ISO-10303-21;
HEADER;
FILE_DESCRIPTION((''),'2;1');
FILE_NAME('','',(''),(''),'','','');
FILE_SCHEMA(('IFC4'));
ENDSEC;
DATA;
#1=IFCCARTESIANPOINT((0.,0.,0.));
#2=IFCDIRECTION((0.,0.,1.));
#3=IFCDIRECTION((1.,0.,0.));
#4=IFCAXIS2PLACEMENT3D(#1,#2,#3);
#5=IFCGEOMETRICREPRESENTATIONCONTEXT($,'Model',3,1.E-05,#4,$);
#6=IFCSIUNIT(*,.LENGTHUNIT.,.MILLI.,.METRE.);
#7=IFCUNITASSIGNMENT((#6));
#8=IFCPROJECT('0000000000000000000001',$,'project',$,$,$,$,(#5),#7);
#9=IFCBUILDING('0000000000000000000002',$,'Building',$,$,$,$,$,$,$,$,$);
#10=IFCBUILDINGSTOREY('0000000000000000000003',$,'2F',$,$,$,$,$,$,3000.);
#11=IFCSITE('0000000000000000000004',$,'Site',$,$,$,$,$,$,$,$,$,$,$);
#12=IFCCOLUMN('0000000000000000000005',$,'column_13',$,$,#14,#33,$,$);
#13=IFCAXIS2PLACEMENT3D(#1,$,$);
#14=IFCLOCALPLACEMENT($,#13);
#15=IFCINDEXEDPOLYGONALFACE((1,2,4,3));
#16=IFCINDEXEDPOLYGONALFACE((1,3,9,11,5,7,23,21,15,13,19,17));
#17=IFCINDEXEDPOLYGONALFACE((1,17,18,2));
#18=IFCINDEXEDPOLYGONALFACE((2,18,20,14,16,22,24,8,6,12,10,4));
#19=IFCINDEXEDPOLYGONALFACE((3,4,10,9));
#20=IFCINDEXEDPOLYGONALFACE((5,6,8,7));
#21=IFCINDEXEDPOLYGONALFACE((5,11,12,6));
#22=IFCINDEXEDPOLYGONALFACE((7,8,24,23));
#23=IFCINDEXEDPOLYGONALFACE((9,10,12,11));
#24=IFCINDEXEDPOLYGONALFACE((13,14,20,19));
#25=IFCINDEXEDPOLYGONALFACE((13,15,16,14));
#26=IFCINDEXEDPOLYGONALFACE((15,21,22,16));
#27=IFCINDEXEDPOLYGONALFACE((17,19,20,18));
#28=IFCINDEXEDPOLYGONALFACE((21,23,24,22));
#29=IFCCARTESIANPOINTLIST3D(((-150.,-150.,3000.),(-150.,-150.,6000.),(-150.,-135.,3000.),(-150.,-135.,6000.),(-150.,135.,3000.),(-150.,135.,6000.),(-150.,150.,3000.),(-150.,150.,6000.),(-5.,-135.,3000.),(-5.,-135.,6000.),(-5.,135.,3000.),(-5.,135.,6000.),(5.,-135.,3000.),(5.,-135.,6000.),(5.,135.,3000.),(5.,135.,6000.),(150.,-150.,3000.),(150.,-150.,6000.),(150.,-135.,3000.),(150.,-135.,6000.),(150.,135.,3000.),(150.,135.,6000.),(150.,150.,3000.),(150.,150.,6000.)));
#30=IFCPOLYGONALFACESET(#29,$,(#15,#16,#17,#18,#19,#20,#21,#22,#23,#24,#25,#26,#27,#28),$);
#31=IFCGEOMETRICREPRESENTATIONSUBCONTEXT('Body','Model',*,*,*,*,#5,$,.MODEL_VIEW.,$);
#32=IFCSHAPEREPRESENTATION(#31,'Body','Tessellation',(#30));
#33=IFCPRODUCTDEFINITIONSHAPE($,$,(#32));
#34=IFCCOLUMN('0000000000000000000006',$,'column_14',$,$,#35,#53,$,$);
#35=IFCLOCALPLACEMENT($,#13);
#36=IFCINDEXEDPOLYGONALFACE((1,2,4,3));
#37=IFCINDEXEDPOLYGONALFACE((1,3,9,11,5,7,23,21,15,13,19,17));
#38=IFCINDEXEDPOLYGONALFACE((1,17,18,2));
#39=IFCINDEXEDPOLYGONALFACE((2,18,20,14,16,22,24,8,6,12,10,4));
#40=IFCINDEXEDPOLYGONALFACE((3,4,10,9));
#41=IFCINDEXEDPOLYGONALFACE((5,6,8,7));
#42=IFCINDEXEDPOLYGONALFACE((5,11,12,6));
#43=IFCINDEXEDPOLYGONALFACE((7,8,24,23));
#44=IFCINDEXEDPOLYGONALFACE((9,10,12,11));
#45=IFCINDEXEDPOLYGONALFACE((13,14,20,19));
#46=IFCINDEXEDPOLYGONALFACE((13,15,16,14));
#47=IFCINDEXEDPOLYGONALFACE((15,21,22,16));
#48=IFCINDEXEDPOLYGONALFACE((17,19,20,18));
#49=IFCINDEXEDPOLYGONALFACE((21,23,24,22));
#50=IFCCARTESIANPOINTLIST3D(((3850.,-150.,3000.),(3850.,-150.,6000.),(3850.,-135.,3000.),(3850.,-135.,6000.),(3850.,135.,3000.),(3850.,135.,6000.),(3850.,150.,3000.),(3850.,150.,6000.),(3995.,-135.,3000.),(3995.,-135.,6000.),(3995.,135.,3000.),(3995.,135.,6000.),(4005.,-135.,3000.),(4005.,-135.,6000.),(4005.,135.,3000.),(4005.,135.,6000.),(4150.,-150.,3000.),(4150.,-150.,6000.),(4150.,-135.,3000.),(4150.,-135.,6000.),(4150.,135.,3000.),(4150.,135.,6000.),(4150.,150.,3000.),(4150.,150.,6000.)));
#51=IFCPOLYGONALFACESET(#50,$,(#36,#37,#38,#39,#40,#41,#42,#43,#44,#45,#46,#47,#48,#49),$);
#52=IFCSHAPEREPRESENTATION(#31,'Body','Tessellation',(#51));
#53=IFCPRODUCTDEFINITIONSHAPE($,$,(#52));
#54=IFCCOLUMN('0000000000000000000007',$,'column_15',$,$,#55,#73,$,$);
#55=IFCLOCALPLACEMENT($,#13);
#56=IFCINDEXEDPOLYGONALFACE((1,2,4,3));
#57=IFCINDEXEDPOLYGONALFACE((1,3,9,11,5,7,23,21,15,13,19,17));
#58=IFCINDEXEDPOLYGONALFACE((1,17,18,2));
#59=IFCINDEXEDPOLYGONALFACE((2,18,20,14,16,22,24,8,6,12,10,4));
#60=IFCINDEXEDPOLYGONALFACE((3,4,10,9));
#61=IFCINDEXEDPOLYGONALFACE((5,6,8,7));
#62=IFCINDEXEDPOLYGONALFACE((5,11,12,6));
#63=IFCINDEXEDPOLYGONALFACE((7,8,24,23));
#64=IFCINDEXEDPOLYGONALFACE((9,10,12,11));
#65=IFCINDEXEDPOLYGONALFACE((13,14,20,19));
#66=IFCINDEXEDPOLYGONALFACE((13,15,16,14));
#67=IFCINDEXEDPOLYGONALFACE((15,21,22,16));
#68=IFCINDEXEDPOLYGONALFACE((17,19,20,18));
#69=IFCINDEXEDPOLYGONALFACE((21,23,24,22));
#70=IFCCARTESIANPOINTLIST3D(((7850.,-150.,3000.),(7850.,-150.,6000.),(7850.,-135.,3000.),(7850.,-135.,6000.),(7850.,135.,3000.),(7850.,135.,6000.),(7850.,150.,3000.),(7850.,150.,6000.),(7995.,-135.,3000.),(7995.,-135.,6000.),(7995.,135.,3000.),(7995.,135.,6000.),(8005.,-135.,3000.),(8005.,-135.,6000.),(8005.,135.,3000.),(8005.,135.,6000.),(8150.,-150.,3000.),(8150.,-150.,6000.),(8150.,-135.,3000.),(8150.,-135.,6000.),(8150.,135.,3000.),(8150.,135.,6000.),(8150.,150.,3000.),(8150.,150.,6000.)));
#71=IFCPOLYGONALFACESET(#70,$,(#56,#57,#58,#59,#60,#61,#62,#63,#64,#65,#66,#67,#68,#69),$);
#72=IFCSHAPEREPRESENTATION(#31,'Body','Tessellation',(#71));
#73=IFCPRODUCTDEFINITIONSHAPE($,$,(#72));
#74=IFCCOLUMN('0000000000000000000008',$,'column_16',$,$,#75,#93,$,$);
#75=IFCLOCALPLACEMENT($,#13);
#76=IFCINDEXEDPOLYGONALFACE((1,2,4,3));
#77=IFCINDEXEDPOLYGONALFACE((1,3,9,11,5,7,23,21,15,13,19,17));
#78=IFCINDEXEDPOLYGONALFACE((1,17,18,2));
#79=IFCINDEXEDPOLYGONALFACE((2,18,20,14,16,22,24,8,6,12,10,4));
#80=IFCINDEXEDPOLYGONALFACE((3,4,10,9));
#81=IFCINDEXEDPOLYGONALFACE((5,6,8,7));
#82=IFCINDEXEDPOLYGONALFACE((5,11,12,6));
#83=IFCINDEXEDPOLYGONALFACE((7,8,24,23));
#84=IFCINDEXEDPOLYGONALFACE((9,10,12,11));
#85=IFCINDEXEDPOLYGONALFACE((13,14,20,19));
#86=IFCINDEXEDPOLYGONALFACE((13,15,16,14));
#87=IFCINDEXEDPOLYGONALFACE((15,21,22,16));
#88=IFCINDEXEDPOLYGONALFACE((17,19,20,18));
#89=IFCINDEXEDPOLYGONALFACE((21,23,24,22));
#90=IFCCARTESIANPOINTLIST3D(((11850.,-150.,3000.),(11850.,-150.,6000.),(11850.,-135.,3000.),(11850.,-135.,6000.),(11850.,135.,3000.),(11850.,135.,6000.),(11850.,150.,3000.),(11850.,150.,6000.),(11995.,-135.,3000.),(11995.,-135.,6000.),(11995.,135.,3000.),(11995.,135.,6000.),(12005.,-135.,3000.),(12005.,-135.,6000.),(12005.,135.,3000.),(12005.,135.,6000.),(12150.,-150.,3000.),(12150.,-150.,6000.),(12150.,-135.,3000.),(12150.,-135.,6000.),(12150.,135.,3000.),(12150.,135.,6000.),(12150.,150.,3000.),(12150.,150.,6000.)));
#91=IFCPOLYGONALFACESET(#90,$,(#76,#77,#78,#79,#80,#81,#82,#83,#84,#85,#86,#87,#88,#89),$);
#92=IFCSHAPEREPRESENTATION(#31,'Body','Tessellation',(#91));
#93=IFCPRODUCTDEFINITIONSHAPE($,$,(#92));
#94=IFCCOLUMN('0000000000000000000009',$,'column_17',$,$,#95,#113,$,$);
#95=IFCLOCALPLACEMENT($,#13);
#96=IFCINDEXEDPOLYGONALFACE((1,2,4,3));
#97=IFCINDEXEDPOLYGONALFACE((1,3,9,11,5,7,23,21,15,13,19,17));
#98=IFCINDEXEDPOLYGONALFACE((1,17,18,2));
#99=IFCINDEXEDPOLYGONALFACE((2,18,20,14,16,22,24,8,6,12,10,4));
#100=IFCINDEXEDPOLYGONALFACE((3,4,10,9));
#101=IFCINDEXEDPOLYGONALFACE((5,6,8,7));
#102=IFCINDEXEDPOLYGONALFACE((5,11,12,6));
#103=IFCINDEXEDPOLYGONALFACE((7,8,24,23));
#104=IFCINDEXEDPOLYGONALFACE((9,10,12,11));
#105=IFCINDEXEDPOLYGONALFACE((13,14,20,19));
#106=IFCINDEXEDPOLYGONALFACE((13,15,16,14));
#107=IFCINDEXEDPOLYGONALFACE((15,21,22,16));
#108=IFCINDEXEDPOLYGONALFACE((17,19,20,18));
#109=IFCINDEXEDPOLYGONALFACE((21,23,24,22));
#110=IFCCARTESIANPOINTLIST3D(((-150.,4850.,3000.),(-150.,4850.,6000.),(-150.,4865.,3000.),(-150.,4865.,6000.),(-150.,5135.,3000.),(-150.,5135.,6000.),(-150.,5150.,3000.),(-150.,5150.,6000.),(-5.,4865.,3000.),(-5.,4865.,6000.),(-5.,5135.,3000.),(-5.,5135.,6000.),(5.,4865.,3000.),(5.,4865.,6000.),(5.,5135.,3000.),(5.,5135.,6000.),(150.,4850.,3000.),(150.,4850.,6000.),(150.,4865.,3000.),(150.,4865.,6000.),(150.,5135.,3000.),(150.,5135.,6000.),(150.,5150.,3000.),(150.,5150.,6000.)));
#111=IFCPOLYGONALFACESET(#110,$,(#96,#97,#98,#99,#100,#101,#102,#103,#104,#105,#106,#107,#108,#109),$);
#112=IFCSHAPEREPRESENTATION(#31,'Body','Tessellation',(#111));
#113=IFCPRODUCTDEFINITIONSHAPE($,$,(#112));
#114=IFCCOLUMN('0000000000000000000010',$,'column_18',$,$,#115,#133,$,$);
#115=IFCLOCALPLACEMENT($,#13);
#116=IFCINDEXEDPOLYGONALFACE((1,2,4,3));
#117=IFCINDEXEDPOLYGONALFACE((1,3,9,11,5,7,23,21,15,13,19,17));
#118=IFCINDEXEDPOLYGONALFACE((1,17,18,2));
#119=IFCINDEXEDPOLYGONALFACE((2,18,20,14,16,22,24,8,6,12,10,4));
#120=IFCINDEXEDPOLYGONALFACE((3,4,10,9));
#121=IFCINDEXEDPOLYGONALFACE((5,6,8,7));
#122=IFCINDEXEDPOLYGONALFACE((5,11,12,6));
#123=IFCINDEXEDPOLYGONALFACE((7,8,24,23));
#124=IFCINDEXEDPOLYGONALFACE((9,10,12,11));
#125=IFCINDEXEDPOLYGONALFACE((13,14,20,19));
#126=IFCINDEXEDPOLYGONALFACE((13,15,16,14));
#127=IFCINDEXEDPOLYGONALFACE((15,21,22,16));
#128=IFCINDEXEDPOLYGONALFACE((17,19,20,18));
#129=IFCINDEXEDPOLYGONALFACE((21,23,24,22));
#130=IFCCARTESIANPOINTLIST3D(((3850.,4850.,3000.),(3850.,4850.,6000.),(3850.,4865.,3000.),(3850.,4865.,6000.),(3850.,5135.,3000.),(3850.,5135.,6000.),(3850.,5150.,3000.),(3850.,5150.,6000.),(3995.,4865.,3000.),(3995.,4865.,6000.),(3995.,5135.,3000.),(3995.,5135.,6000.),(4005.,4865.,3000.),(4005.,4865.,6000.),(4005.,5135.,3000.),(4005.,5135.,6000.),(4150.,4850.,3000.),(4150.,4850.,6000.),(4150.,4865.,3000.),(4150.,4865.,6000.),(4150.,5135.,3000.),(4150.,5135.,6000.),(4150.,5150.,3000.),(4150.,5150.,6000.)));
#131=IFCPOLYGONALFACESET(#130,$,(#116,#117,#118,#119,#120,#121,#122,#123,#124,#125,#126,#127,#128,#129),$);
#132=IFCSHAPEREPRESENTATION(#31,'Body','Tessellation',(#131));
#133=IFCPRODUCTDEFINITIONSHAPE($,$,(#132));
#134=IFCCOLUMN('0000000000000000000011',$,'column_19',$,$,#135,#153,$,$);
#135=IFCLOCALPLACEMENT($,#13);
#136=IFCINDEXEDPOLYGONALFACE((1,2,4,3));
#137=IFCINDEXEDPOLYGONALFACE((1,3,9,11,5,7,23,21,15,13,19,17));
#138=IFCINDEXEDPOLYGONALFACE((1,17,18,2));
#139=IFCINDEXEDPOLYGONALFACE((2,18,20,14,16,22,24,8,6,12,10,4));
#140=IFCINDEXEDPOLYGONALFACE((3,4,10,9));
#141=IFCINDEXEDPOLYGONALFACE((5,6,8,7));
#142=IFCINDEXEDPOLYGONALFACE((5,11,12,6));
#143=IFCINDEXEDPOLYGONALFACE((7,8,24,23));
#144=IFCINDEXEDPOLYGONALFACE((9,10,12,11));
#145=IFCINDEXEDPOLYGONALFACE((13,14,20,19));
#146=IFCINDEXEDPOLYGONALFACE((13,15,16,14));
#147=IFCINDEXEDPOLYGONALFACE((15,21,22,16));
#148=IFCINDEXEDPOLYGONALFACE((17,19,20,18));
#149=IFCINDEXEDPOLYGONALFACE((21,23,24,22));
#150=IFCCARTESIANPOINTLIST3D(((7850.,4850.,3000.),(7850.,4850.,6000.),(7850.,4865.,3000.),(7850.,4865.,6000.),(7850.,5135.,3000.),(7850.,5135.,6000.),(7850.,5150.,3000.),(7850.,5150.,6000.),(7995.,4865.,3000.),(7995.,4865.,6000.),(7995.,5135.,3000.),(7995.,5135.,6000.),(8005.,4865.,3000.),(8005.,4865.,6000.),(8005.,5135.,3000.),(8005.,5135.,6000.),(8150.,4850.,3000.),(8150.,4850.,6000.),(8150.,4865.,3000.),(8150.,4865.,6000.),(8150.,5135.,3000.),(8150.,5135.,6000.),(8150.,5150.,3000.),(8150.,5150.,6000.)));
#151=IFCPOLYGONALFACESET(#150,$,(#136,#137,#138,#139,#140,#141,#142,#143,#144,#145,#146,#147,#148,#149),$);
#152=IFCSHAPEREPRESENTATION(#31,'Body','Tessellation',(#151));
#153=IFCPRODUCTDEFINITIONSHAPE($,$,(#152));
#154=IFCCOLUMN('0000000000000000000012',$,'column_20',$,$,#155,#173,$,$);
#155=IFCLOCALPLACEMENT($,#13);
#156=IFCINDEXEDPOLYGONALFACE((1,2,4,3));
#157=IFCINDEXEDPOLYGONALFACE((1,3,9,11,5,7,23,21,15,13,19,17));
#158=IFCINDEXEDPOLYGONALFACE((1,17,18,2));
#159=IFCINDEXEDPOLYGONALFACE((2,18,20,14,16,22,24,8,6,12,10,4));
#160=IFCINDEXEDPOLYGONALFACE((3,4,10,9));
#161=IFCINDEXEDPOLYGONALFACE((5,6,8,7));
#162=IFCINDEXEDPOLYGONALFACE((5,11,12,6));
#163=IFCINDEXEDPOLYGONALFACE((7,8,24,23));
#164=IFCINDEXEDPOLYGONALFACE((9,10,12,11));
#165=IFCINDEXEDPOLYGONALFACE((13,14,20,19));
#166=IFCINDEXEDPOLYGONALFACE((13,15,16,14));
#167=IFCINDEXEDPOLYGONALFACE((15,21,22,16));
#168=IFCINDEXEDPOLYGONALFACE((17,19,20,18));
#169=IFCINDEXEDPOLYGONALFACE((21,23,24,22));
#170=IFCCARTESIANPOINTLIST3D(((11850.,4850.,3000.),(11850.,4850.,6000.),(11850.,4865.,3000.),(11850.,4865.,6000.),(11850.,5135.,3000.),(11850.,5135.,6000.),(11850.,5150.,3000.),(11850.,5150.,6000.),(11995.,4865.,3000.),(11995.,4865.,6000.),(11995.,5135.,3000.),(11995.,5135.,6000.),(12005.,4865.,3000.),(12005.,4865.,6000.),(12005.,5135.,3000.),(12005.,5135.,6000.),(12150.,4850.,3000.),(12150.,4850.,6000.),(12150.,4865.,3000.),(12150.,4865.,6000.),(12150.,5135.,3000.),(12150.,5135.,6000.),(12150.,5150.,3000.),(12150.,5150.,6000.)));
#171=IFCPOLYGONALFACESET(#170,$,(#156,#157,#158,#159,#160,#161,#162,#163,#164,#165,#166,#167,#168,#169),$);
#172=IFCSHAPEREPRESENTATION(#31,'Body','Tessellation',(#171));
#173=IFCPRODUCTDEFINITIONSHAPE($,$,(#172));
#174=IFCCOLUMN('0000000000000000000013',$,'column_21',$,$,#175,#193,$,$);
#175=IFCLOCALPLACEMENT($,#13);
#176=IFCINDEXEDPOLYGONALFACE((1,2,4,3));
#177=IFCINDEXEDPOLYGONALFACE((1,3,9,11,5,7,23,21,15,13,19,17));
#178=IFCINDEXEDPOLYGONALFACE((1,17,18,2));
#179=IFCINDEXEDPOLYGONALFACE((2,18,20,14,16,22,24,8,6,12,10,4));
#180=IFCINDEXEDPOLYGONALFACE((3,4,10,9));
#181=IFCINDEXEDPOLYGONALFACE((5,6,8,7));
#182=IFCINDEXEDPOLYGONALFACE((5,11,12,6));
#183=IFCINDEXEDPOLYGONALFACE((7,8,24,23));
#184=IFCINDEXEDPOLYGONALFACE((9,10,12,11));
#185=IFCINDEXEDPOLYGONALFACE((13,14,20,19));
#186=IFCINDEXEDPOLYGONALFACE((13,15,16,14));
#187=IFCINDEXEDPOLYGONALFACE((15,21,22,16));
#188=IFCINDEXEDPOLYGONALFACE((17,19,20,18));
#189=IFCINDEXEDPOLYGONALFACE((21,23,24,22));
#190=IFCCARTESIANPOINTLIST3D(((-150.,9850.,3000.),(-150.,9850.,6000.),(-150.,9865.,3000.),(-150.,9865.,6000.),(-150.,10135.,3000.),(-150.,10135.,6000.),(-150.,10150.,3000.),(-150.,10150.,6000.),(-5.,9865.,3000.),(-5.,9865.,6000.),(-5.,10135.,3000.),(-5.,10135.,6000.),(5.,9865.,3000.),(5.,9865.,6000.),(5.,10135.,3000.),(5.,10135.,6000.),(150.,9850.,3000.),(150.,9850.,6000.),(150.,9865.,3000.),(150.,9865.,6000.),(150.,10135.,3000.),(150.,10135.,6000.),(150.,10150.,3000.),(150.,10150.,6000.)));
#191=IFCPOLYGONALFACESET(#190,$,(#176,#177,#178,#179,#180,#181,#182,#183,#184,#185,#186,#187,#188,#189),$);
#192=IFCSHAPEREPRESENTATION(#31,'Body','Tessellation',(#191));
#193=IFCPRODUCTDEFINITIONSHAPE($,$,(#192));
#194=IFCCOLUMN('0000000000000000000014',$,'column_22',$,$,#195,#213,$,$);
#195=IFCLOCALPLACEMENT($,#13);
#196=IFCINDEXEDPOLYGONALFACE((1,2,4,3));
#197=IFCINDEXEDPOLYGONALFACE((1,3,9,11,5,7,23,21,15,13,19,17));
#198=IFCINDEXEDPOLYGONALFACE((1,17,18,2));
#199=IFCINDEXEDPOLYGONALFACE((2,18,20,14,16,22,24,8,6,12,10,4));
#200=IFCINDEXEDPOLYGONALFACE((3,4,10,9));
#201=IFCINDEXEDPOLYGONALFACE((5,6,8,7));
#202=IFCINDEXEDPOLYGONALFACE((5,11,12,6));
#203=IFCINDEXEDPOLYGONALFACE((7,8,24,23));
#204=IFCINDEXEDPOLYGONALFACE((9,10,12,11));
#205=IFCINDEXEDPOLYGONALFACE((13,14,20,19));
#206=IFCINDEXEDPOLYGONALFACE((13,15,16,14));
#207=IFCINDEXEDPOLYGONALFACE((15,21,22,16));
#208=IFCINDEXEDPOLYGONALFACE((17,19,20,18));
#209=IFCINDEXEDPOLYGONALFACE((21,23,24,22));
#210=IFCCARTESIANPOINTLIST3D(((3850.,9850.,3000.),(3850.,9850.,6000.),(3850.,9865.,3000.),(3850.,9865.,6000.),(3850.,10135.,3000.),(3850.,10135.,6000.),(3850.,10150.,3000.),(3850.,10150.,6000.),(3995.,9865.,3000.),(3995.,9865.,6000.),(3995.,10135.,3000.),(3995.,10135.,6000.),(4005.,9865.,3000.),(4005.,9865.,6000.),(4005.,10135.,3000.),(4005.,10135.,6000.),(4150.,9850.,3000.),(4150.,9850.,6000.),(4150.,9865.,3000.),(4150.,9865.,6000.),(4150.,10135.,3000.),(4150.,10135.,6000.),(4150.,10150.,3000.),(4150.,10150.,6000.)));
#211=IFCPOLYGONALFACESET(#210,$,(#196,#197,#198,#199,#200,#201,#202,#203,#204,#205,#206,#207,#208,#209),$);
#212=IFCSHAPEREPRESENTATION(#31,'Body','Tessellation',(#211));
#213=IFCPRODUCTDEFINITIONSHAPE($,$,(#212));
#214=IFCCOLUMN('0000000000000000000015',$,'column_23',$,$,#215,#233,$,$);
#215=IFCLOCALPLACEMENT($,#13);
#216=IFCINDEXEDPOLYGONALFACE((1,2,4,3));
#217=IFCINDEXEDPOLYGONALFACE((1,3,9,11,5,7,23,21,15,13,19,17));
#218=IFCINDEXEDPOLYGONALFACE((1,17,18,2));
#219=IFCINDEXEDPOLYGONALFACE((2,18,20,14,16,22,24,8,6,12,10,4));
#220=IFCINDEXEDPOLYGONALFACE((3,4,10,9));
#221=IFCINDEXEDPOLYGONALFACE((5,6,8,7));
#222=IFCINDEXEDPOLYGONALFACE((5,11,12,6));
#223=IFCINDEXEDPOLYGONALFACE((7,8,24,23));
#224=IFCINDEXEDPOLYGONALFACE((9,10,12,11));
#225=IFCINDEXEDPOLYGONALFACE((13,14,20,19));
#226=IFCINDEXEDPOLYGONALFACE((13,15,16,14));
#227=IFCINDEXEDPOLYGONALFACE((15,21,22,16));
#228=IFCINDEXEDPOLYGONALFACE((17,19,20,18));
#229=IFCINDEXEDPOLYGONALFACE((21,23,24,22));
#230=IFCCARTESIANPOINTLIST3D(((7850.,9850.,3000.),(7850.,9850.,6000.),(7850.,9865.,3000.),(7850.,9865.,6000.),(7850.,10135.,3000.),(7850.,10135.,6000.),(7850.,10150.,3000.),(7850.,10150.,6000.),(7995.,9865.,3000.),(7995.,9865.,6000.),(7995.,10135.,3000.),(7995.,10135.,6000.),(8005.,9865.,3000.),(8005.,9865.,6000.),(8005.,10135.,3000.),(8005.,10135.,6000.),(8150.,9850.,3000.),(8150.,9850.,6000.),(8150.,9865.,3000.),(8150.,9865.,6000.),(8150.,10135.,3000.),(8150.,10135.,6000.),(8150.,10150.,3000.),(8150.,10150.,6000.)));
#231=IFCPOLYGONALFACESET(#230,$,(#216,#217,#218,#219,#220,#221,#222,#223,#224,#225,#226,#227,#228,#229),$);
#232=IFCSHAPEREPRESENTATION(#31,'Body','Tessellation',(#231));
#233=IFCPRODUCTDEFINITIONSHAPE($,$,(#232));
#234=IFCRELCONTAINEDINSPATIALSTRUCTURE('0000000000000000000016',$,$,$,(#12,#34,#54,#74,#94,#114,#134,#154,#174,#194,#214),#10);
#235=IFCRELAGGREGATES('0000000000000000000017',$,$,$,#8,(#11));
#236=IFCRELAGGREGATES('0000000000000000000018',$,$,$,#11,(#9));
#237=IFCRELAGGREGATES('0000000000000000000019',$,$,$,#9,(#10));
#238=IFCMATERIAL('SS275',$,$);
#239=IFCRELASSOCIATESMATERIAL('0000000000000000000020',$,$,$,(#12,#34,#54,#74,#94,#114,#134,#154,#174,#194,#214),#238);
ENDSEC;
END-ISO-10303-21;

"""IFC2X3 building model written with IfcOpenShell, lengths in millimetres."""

from ifc_helpers import new_model, si_unit, frame, origin, origin_with_axes, origin_2d_with_axis, place, context, subcontext, project, spatial, i_section, extrude, material, element, save


model = new_model("IFC2X3")

# Units and contexts
model_context = context("Model", 3, precision=1e-05, world=origin_with_axes())
body_context = subcontext(model_context, "Body", "Model", "MODEL_VIEW")
ifc_project = project(units=[si_unit("LENGTHUNIT", "METRE", prefix="MILLI")], contexts=[model_context])

# Site, building, storey
site = spatial("IfcSite", under=ifc_project, Name="Site")
building = spatial("IfcBuilding", under=site, Name="Building")
storey = spatial("IfcBuildingStorey", under=building, Name="2F", Elevation=3000.0)

# Columns
ifc_material = material(Name="SS275")
for number, where, z_axis, x_axis, name in (
    (1, (0.0, 0.0, 3000.0), (0.0, 0.0, 1.0), (1.0, 0.0, 0.0), "column_13"),
    (2, (4000.0, 0.0, 3000.0), (0.0, 0.0, 1.0), (1.0, 0.0, 0.0), "column_14"),
    (3, (8000.0, 0.0, 3000.0), (0.0, 0.0, 1.0), (1.0, 0.0, 0.0), "column_15"),
    (4, (12000.0, 0.0, 3000.0), (0.0, 0.0, 1.0), (1.0, 0.0, 0.0), "column_16"),
    (5, (0.0, 5000.0, 3000.0), (0.0, 0.0, 1.0), (1.0, 0.0, 0.0), "column_17"),
    (6, (4000.0, 5000.0, 3000.0), (0.0, 0.0, 1.0), (1.0, 0.0, 0.0), "column_18"),
    (7, (8000.0, 5000.0, 3000.0), (0.0, 0.0, 1.0), (1.0, 0.0, 0.0), "column_19"),
    (8, (12000.0, 5000.0, 3000.0), (0.0, 0.0, 1.0), (1.0, 0.0, 0.0), "column_20"),
    (9, (0.0, 10000.0, 3000.0), (0.0, 0.0, 1.0), (1.0, 0.0, 0.0), "column_21"),
    (10, (4000.0, 10000.0, 3000.0), (0.0, 0.0, 1.0), (1.0, 0.0, 0.0), "column_22"),
    (11, (8000.0, 10000.0, 3000.0), (0.0, 0.0, 1.0), (1.0, 0.0, 0.0), "column_23"),
):
    element("IfcColumn", number, at=place(None, frame(where, z_axis=z_axis, x_axis=x_axis)), inside=storey, material=ifc_material, Name=name, context=body_context, shape_type="SweptSolid", body=[
        extrude(i_section(OverallWidth=300.0, OverallDepth=300.0, WebThickness=10.0, FlangeThickness=15.0, at=origin_2d_with_axis()), origin(), (0.0, 0.0, 1.0), 3000.0),
    ])

save(model, "model.ifc")
